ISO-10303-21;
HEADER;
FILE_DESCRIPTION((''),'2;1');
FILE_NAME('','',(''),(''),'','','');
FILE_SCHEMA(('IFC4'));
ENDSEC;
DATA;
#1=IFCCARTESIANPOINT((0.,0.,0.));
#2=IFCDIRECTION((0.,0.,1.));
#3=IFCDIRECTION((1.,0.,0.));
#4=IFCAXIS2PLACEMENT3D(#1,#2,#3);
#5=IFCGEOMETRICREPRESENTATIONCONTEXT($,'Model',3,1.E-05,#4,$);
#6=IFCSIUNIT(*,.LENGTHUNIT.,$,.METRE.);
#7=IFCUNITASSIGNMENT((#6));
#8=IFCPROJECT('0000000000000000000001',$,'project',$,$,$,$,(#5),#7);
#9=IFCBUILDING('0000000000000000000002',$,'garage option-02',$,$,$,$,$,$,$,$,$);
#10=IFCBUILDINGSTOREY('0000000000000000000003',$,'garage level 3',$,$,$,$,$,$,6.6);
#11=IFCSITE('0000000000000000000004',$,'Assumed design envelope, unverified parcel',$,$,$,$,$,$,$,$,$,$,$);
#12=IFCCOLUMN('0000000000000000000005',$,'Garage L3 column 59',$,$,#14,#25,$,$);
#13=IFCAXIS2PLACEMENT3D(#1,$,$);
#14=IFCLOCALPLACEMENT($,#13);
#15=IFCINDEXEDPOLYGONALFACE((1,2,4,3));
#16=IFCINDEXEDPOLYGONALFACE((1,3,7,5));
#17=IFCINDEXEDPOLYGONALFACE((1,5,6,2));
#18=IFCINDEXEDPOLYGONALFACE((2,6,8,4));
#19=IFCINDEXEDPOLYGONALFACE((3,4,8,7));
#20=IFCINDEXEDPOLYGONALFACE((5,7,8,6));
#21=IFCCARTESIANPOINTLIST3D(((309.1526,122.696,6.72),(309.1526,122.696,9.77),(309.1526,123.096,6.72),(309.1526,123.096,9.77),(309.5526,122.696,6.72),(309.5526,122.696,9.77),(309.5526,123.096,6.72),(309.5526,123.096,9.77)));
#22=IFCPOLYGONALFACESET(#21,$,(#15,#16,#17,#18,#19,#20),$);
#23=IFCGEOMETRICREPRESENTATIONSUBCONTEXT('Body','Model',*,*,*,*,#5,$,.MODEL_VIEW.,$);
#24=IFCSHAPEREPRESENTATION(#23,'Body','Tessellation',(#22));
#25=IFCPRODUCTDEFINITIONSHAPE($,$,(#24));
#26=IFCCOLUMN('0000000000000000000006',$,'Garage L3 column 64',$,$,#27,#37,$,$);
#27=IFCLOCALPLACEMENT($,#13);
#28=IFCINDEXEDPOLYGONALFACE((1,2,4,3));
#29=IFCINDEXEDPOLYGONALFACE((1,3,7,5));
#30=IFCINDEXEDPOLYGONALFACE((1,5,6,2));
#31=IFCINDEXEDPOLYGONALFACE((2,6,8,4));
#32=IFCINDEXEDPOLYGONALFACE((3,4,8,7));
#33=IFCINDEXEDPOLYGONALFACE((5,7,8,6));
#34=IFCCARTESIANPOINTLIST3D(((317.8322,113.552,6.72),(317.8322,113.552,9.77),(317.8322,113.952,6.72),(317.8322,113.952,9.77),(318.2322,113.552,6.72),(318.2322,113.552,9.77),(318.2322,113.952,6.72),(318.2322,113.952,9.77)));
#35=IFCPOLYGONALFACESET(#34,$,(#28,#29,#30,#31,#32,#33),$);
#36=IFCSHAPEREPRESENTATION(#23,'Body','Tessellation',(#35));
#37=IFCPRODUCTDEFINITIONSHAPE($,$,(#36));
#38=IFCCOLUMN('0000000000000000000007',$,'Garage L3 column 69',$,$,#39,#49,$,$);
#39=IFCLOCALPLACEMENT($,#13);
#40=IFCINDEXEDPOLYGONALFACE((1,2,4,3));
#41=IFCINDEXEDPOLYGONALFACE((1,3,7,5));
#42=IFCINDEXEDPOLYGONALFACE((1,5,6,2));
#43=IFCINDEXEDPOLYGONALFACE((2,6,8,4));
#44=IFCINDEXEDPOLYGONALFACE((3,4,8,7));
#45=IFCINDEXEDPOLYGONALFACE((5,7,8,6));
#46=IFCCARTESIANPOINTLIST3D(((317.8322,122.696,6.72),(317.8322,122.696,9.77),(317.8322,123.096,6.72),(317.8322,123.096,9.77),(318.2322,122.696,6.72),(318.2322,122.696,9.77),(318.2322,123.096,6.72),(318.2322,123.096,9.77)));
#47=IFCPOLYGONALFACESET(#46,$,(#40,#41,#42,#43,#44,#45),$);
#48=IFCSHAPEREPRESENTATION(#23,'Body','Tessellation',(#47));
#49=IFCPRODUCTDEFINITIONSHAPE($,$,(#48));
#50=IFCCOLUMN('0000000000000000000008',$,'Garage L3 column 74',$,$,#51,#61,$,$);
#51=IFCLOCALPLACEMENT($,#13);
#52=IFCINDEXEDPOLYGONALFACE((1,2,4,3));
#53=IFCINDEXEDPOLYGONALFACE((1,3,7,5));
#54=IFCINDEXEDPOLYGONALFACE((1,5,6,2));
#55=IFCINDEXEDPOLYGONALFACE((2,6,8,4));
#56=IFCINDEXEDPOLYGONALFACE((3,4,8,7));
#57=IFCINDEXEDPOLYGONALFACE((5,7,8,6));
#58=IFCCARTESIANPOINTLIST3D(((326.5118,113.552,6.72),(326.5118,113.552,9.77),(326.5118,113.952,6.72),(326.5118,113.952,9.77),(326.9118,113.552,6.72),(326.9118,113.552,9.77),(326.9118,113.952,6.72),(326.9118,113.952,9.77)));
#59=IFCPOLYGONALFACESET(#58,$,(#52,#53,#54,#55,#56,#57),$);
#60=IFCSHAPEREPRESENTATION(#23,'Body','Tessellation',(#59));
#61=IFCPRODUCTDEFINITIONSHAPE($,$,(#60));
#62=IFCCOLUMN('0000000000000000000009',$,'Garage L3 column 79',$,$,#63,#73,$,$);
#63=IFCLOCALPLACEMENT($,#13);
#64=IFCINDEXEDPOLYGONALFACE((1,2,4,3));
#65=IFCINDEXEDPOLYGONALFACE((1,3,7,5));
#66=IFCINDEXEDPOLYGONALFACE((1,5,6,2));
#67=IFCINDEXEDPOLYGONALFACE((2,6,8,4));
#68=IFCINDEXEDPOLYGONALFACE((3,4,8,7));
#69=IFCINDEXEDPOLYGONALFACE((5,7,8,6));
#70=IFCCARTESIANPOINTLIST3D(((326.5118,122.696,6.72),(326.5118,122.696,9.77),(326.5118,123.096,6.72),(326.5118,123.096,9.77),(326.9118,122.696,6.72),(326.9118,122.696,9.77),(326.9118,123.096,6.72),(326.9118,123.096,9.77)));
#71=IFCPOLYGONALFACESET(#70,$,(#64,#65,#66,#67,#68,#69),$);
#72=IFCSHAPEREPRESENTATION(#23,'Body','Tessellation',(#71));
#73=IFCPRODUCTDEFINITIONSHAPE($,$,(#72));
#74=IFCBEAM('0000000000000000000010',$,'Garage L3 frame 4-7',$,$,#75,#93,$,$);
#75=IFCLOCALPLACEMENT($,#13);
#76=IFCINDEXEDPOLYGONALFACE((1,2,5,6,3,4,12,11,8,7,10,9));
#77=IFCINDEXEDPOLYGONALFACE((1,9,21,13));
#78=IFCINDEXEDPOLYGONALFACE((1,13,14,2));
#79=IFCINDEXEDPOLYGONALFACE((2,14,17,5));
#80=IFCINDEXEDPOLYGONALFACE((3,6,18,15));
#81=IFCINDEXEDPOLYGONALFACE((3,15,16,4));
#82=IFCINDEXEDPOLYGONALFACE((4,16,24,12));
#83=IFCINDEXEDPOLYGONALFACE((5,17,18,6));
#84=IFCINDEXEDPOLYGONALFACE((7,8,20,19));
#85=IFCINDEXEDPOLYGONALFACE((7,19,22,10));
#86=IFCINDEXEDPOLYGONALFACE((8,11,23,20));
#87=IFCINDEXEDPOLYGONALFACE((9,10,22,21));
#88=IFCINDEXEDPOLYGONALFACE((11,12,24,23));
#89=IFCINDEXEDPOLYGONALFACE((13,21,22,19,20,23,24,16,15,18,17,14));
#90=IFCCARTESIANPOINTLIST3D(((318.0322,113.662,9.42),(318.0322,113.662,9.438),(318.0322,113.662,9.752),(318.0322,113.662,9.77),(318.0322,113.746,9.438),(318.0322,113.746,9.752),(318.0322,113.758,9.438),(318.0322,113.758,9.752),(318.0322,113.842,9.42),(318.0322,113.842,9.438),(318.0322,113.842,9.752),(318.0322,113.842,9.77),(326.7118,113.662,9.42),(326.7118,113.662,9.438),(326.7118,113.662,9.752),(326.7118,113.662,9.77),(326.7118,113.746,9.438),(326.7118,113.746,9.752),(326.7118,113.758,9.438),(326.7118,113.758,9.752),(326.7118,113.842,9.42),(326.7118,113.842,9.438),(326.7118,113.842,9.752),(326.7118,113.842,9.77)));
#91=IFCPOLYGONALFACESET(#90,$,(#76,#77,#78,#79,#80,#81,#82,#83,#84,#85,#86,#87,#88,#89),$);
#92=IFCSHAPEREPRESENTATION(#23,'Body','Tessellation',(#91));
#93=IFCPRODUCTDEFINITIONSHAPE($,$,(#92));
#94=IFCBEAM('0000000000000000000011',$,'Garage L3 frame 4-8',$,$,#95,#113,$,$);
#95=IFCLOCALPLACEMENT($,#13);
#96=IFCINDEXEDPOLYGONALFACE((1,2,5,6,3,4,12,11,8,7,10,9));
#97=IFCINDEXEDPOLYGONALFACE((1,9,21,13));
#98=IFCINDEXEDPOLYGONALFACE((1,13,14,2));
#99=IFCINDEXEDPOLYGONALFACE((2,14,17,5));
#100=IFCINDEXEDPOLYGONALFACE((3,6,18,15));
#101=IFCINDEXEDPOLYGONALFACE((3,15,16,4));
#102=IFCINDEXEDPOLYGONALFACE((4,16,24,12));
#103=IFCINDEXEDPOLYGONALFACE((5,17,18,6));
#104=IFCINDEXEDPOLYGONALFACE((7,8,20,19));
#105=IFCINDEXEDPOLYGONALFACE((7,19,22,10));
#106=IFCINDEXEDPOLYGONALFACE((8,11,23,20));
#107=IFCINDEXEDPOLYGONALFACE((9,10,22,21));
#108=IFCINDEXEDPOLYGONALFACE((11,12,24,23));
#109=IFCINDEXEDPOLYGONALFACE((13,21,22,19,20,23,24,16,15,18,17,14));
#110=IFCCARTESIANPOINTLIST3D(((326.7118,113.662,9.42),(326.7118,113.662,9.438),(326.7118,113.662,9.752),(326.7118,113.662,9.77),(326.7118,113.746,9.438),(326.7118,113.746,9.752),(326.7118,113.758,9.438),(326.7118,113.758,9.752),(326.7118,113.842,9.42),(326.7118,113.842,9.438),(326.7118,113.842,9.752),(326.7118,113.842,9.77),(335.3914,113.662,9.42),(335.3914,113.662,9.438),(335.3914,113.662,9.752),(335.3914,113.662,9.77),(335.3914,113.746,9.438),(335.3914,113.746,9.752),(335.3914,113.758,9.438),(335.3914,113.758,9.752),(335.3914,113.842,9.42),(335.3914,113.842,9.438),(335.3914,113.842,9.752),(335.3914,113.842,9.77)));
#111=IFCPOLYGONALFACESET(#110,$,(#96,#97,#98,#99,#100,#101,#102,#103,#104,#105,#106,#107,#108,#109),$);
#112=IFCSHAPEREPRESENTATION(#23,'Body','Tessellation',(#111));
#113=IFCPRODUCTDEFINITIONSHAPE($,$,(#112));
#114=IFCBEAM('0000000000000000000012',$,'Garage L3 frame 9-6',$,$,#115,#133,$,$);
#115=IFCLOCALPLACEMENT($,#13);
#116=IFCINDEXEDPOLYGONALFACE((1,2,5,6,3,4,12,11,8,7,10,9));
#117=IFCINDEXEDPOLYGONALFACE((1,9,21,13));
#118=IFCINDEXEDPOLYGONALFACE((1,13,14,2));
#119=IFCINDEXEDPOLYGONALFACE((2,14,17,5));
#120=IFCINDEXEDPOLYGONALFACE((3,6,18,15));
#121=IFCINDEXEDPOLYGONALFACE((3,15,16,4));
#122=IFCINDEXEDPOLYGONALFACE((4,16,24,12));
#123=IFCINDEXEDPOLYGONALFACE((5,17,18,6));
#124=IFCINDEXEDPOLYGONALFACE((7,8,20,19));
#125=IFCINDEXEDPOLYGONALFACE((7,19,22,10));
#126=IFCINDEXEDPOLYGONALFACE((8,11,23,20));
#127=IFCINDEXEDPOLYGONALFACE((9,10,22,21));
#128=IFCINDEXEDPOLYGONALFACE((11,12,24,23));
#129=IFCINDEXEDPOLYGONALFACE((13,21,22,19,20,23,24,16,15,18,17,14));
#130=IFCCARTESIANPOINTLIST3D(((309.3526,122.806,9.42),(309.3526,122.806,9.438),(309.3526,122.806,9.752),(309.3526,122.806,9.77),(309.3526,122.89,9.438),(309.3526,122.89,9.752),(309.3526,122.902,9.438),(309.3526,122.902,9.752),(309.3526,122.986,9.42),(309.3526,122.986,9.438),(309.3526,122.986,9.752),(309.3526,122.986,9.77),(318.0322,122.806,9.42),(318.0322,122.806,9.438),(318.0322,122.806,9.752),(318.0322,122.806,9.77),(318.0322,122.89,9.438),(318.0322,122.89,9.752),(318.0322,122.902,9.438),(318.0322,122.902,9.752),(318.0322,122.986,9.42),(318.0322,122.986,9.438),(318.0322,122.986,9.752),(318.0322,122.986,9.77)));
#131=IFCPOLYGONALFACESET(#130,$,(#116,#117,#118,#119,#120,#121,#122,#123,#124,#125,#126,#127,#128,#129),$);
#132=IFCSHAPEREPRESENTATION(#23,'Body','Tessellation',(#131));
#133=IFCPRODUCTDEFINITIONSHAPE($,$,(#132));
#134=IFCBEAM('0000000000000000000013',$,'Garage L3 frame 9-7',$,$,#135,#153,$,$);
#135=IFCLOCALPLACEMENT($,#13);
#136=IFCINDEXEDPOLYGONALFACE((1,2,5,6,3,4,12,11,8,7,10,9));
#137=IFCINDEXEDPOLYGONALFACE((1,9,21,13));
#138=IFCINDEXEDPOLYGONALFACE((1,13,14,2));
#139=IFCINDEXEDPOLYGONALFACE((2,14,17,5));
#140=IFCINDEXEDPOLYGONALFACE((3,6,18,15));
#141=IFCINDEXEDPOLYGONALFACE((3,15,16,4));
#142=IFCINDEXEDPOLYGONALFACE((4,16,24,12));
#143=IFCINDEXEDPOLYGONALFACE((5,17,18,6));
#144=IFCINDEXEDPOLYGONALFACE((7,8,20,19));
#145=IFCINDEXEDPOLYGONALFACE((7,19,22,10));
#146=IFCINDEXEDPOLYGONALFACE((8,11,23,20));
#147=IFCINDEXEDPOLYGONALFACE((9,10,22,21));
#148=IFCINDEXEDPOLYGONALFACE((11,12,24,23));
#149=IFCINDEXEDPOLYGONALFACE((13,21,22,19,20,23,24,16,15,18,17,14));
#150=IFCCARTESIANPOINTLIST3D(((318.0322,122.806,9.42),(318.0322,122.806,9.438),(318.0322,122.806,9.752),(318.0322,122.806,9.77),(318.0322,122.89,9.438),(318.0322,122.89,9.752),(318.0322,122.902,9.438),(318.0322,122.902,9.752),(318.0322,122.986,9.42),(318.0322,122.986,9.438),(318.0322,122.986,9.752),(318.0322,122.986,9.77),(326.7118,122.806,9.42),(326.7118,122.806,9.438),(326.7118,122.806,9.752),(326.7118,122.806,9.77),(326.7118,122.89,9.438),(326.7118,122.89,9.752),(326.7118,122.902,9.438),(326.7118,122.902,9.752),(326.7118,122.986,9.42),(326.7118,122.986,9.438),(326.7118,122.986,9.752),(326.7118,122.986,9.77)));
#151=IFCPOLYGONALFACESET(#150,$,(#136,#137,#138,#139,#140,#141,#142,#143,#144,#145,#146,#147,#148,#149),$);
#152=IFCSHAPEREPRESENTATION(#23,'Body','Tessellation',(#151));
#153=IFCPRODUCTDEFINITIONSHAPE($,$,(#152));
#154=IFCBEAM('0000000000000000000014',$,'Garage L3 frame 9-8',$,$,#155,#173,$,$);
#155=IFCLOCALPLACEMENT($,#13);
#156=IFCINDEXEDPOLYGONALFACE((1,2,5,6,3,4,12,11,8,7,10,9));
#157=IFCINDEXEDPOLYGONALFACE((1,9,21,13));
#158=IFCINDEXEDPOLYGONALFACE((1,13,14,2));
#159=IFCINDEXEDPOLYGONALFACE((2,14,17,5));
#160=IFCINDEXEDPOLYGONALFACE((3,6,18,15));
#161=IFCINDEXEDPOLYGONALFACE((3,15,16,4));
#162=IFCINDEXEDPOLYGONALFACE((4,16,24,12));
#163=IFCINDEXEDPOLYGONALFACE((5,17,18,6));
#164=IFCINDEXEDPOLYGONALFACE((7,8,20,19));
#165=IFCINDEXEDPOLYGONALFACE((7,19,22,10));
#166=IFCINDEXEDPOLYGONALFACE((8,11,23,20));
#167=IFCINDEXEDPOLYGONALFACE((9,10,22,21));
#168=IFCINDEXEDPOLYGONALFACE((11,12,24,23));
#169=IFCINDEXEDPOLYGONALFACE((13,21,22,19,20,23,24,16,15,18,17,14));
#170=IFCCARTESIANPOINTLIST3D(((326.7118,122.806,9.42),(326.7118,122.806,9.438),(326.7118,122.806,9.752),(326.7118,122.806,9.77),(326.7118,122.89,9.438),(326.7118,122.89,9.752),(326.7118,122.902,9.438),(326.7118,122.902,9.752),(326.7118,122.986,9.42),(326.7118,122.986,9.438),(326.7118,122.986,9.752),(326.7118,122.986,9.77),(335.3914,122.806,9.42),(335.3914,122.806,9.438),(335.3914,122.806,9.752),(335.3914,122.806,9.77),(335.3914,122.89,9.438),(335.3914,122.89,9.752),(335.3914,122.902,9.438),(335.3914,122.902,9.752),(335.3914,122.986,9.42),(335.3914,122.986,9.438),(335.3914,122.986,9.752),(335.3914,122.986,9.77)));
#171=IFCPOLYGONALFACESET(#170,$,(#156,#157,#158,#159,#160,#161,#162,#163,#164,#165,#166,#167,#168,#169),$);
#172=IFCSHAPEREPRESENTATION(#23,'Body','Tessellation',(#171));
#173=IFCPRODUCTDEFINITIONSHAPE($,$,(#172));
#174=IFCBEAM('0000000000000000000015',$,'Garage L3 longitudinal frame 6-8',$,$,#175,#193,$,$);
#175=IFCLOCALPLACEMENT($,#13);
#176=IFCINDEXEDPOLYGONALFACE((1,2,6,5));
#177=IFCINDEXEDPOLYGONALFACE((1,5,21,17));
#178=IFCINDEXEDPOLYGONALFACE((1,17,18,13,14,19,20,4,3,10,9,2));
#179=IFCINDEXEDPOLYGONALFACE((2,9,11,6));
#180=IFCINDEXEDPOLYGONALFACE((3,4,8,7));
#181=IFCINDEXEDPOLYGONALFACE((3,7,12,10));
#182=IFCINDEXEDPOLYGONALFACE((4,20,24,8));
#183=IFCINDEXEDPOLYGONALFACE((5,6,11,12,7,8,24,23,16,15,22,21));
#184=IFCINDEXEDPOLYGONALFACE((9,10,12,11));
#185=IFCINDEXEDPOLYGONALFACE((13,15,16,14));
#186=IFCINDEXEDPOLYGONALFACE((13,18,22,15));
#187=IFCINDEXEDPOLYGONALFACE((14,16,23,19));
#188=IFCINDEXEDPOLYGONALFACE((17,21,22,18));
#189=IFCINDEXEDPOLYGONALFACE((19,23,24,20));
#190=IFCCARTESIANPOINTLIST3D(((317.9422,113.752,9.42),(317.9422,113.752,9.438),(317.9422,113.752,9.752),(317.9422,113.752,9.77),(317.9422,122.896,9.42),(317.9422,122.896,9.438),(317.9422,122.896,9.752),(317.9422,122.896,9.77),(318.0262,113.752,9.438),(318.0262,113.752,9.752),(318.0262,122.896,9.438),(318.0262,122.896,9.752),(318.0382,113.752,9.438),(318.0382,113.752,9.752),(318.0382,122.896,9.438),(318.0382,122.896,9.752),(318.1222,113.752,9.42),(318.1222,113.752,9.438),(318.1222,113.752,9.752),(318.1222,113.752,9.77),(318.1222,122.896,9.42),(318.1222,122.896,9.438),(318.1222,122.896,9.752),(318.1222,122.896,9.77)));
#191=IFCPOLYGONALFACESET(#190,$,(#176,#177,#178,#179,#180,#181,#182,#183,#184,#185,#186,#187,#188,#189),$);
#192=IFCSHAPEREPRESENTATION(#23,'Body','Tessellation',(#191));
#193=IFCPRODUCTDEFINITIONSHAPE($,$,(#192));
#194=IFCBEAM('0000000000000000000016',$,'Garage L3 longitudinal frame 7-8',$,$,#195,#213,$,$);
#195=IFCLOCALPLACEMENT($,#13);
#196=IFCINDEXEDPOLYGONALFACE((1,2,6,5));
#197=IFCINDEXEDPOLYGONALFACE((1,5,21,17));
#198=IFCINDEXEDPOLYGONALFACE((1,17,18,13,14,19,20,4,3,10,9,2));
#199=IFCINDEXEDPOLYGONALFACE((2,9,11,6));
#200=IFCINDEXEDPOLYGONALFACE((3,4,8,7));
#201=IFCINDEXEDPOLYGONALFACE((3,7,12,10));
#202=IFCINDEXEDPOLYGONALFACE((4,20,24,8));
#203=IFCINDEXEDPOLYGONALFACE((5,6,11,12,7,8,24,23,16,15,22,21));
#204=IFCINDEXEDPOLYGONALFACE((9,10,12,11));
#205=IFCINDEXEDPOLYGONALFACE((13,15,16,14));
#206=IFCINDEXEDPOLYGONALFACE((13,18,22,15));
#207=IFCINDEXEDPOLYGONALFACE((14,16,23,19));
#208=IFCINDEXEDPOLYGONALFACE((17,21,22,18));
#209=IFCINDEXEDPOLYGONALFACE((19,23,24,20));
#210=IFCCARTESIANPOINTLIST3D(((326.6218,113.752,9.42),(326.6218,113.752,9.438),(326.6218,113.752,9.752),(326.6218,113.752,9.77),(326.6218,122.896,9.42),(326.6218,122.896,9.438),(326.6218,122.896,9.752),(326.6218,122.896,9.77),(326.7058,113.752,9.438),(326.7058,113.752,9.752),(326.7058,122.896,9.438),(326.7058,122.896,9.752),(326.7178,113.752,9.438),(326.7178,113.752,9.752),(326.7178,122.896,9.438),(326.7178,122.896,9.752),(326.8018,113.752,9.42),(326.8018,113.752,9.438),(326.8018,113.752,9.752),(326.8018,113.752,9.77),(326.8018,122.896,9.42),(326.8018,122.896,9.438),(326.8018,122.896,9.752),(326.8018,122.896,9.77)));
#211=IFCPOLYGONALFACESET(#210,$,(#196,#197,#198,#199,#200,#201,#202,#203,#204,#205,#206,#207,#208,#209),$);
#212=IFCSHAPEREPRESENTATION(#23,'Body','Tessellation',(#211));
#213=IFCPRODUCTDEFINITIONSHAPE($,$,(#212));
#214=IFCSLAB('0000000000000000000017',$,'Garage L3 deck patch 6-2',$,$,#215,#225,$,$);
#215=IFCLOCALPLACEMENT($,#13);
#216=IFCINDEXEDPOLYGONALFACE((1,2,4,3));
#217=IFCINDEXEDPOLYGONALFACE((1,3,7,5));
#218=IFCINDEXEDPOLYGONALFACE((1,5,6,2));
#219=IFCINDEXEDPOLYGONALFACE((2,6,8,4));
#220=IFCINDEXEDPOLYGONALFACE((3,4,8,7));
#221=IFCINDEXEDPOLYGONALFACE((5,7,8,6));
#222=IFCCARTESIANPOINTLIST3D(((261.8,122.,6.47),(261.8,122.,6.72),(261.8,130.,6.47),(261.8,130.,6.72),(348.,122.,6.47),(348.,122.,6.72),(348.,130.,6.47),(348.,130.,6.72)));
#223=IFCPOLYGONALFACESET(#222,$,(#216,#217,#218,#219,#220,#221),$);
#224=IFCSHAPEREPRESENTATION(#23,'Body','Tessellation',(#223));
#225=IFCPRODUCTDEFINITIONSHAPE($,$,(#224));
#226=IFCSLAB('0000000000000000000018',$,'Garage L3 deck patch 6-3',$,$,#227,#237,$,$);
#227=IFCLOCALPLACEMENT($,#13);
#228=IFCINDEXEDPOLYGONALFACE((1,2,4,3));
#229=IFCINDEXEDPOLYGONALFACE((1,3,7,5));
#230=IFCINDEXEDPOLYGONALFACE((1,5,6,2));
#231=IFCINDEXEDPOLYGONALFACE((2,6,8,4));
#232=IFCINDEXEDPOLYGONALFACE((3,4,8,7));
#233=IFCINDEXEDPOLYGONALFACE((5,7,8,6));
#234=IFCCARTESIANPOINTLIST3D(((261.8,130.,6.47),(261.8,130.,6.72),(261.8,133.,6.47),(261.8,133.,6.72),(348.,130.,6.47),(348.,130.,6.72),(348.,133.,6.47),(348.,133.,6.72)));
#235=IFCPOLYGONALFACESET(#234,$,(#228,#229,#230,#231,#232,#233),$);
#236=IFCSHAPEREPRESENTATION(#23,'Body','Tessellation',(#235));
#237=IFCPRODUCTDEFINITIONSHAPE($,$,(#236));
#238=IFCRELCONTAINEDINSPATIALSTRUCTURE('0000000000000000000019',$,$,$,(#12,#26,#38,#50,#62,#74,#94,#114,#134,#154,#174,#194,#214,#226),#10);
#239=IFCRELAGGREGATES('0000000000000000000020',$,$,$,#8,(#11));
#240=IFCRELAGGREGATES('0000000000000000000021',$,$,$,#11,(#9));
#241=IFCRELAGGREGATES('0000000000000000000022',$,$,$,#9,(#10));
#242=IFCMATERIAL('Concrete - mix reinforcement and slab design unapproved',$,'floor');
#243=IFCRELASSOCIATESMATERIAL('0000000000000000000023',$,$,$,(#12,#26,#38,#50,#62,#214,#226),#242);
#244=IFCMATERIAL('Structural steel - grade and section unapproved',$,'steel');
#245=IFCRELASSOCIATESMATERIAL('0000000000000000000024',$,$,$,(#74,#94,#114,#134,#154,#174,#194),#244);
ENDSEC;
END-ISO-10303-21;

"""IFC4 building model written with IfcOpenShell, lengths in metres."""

from ifc_helpers import new_model, si_unit, frame, origin_with_axes, place, context, subcontext, project, spatial, rectangle, i_section, extrude, material, element, save


model = new_model("IFC4")

# Units and contexts
model_context = context("Model", 3, precision=1e-05, world=origin_with_axes())
body_context = subcontext(model_context, "Body", "Model", "MODEL_VIEW")
ifc_project = project(units=[si_unit("LENGTHUNIT", "METRE")], contexts=[model_context])

# Site, building, storey
site = spatial("IfcSite", under=ifc_project, Name="Assumed design envelope, unverified parcel")
building = spatial("IfcBuilding", under=site, Name="garage option-02")
storey = spatial("IfcBuildingStorey", under=building, Name="garage level 3", Elevation=6.6)

# Columns
ifc_material_1 = material(Name="Concrete - mix reinforcement and slab design unapproved", Category="floor")
for number, where, z_axis, x_axis, name in (
    (1, (309.3526, 122.896, 6.72), (0.0, 0.0, 1.0), (1.0, 0.0, 0.0), "Garage L3 column 59"),
    (2, (318.0322, 113.752, 6.72), (0.0, 0.0, 1.0), (1.0, 0.0, 0.0), "Garage L3 column 64"),
    (3, (318.0322, 122.896, 6.72), (0.0, 0.0, 1.0), (1.0, 0.0, 0.0), "Garage L3 column 69"),
    (4, (326.7118, 113.752, 6.72), (0.0, 0.0, 1.0), (1.0, 0.0, 0.0), "Garage L3 column 74"),
    (5, (326.7118, 122.896, 6.72), (0.0, 0.0, 1.0), (1.0, 0.0, 0.0), "Garage L3 column 79"),
):
    element("IfcColumn", number, at=place(None, frame(where, z_axis=z_axis, x_axis=x_axis)), inside=storey, material=ifc_material_1, Name=name, context=body_context, shape_type="SweptSolid", body=[
        extrude(rectangle(XDim=0.4, YDim=0.4), origin_with_axes(), (0.0, 0.0, 1.0), 3.05),
    ])

# Beams
ifc_material_2 = material(Name="Structural steel - grade and section unapproved", Category="steel")
for number, where, z_axis, x_axis, name in (
    (6, (318.0322, 113.752, 9.595), (1.0, 0.0, 0.0), (0.0, 1.0, 0.0), "Garage L3 frame 4-7"),
    (7, (326.7118, 113.752, 9.595), (1.0, 0.0, 0.0), (0.0, 1.0, 0.0), "Garage L3 frame 4-8"),
    (8, (309.3526, 122.896, 9.595), (1.0, 0.0, 0.0), (0.0, 1.0, 0.0), "Garage L3 frame 9-6"),
    (9, (318.0322, 122.896, 9.595), (1.0, 0.0, 0.0), (0.0, 1.0, 0.0), "Garage L3 frame 9-7"),
    (10, (326.7118, 122.896, 9.595), (1.0, 0.0, 0.0), (0.0, 1.0, 0.0), "Garage L3 frame 9-8"),
):
    element("IfcBeam", number, at=place(None, frame(where, z_axis=z_axis, x_axis=x_axis)), inside=storey, material=ifc_material_2, Name=name, context=body_context, shape_type="SweptSolid", body=[
        extrude(i_section(OverallWidth=0.18, OverallDepth=0.35, WebThickness=0.012, FlangeThickness=0.018, FilletRadius=0.0), origin_with_axes(), (0.0, 0.0, 1.0), 8.6796),
    ])
for number, where, z_axis, x_axis, name in (
    (11, (318.0322, 113.752, 9.595), (0.0, 1.0, 0.0), (-1.0, 0.0, 0.0), "Garage L3 longitudinal frame 6-8"),
    (12, (326.7118, 113.752, 9.595), (0.0, 1.0, 0.0), (-1.0, 0.0, 0.0), "Garage L3 longitudinal frame 7-8"),
):
    element("IfcBeam", number, at=place(None, frame(where, z_axis=z_axis, x_axis=x_axis)), inside=storey, material=ifc_material_2, Name=name, context=body_context, shape_type="SweptSolid", body=[
        extrude(i_section(OverallWidth=0.18, OverallDepth=0.35, WebThickness=0.012, FlangeThickness=0.018, FilletRadius=0.0), origin_with_axes(), (0.0, 0.0, 1.0), 9.144),
    ])

# Slabs
slab_1_placement = place(None, frame((304.9, 126.0, 6.47), z_axis=(0.0, 0.0, 1.0), x_axis=(1.0, 0.0, 0.0)))
element("IfcSlab", 13, at=slab_1_placement, inside=storey, material=ifc_material_1, Name="Garage L3 deck patch 6-2", context=body_context, shape_type="SweptSolid", body=[
    extrude(rectangle(XDim=86.2, YDim=8.0), origin_with_axes(), (0.0, 0.0, 1.0), 0.25),
])
for number, where, z_axis, x_axis, name in (
    (14, (304.9, 131.5, 6.47), (0.0, 0.0, 1.0), (1.0, 0.0, 0.0), "Garage L3 deck patch 6-3"),
):
    element("IfcSlab", number, at=place(None, frame(where, z_axis=z_axis, x_axis=x_axis)), inside=storey, material=ifc_material_1, Name=name, context=body_context, shape_type="SweptSolid", body=[
        extrude(rectangle(XDim=86.2, YDim=3.0), origin_with_axes(), (0.0, 0.0, 1.0), 0.25),
    ])

save(model, "model.ifc")
